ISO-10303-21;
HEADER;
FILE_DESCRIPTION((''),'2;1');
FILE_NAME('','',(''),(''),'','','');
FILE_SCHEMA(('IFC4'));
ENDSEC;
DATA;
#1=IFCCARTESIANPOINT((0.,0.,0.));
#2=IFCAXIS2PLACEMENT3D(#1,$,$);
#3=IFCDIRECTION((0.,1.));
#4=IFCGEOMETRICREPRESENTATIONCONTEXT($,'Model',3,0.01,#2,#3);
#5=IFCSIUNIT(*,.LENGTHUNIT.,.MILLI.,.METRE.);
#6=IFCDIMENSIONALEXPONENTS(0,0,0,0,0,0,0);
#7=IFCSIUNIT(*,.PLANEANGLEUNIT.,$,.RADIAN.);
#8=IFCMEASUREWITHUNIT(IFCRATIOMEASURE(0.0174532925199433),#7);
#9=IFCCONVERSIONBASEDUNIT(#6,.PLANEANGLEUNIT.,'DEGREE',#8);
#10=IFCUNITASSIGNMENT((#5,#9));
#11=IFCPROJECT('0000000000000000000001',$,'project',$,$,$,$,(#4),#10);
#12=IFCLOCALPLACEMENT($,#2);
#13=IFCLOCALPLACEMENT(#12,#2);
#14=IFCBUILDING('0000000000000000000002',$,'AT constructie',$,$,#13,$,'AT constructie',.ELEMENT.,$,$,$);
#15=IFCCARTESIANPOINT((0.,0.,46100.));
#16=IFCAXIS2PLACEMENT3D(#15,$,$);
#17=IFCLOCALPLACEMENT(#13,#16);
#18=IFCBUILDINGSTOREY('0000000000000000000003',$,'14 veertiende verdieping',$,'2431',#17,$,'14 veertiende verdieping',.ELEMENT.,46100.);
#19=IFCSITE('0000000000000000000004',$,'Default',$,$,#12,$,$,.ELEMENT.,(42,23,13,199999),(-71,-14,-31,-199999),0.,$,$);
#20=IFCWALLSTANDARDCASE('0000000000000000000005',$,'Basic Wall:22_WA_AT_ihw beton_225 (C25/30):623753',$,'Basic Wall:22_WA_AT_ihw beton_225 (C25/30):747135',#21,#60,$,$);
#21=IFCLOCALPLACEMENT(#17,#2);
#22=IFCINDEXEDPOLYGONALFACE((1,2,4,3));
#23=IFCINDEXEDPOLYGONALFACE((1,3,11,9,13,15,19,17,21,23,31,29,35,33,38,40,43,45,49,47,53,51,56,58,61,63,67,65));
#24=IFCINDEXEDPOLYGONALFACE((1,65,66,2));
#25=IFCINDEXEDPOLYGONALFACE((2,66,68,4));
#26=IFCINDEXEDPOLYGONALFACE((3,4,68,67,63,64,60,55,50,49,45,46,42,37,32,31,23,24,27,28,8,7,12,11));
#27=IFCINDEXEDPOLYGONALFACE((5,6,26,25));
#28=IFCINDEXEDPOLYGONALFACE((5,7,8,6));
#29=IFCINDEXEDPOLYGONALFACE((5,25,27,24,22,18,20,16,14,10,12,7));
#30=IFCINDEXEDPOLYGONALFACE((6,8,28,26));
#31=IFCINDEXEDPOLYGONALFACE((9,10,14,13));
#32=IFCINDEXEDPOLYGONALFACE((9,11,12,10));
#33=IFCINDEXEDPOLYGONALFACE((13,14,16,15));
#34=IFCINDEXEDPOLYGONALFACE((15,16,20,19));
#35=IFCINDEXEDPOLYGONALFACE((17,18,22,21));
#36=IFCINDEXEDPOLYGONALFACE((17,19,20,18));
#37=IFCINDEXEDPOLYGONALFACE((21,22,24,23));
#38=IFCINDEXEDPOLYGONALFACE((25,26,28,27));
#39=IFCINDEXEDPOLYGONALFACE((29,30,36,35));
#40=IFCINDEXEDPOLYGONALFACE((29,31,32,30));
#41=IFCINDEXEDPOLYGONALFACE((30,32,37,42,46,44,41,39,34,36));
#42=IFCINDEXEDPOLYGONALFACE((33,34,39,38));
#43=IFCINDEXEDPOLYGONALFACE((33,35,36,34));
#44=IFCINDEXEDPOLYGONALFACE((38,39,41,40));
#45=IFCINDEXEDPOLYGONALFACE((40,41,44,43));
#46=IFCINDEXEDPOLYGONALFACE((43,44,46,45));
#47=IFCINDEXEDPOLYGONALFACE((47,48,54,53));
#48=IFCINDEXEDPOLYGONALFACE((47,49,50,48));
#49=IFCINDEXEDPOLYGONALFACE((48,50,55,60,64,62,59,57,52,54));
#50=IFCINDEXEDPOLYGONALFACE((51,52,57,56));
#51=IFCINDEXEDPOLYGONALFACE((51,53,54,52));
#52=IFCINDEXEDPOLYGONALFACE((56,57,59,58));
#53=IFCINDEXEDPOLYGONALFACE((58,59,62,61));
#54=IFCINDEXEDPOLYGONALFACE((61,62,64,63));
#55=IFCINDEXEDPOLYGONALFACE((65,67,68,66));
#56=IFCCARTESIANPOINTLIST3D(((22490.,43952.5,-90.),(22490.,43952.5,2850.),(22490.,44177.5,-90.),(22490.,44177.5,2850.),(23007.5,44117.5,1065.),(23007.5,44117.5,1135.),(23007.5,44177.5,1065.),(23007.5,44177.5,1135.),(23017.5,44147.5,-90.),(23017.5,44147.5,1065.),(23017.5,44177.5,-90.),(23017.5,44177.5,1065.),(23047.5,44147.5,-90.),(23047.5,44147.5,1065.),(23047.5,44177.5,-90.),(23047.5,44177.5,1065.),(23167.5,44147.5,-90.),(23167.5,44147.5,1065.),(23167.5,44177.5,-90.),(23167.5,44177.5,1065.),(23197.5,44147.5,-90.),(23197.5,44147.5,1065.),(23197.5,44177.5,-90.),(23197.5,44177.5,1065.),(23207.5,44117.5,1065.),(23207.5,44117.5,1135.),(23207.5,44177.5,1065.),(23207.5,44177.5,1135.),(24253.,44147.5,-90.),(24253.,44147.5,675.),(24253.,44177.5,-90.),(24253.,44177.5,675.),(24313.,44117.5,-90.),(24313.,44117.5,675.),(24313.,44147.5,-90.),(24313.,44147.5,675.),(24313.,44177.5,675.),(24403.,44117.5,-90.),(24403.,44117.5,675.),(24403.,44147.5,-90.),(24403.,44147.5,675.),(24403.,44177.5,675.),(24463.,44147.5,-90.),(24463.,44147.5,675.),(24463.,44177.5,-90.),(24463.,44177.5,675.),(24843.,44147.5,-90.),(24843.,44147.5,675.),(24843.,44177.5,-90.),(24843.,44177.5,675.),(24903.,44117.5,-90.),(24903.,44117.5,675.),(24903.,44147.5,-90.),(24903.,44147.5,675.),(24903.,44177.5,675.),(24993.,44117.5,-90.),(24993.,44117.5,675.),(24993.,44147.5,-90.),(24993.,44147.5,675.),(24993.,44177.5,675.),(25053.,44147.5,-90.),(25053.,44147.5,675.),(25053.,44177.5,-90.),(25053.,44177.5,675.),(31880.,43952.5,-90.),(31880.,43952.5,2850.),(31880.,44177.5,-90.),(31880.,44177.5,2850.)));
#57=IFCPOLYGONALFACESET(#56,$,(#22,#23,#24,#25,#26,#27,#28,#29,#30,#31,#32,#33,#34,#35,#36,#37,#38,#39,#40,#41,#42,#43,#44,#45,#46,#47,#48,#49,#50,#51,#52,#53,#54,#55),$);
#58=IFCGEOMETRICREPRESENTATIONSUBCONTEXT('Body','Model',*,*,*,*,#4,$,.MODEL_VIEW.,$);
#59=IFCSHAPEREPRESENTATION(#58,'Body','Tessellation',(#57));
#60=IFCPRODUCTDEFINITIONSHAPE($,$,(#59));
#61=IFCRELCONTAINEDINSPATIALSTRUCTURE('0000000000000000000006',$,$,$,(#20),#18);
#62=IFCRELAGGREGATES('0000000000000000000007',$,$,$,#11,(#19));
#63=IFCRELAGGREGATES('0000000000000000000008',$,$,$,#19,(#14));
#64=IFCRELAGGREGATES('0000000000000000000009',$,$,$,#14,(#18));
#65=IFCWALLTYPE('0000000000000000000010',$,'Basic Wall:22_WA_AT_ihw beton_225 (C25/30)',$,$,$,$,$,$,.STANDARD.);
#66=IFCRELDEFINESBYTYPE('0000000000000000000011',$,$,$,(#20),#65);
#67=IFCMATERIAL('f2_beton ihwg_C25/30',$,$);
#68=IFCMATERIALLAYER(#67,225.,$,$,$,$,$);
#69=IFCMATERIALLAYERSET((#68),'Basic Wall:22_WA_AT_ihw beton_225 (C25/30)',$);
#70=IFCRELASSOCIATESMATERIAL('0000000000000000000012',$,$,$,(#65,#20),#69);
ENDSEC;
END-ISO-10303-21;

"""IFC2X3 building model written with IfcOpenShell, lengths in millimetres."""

from ifc_helpers import new_model, entity, si_unit, converted_unit, direction, frame, frame_2d, origin, place, context, subcontext, project, spatial, rectangle, extrude, material, layer, layer_set, layer_usage, type_object, element, save


model = new_model("IFC2X3")

# Units and contexts
model_context = context("Model", 3, precision=0.01, world=origin(), true_north=direction((0.0, 1.0)))
body_context = subcontext(model_context, "Body", "Model", "MODEL_VIEW")
ifc_project = project(units=[si_unit("LENGTHUNIT", "METRE", prefix="MILLI"), converted_unit("PLANEANGLEUNIT", "DEGREE", entity("IfcRatioMeasure", 0.0174532925199433), si_unit("PLANEANGLEUNIT", "RADIAN"), dimensions=[0, 0, 0, 0, 0, 0, 0])], contexts=[model_context])

# Site, building, storey
site_placement = place(None, origin())
site = spatial("IfcSite", under=ifc_project, at=site_placement, Name="Default", CompositionType="ELEMENT", RefLatitude=(42, 23, 13, 199999), RefLongitude=(-71, -14, -31, -199999), RefElevation=0.0)
building_placement = place(site_placement, origin())
building = spatial("IfcBuilding", under=site, at=building_placement, Name="AT constructie", LongName="AT constructie", CompositionType="ELEMENT")
storey_placement = place(building_placement, frame((0.0, 0.0, 46100.0)))
storey = spatial("IfcBuildingStorey", under=building, at=storey_placement, Name="14 veertiende verdieping", ObjectType="2431", LongName="14 veertiende verdieping", CompositionType="ELEMENT", Elevation=46100.0)

# Shared definitions
ifc_material_1 = material(Name="f2_beton ihwg_C25/30")

# Wall, openings
ifc_layer_1 = layer(ifc_material_1, 225.0)
ifc_layer_set_1 = layer_set([ifc_layer_1], Name="Basic Wall:22_WA_AT_ihw beton_225 (C25/30)")
ifc_layer_usage_1 = layer_usage(ifc_layer_set_1, "AXIS2", "NEGATIVE", 112.5)
wall_type = type_object("IfcWallType", Name="Basic Wall:22_WA_AT_ihw beton_225 (C25/30)", PredefinedType="STANDARD", material=ifc_layer_set_1)
wall_placement = place(storey_placement, frame((22490.0, 44065.0, -90.0)))
wall = element("IfcWallStandardCase", 1, at=wall_placement, inside=storey, type_object=wall_type, material=ifc_layer_usage_1, Name="Basic Wall:22_WA_AT_ihw beton_225 (C25/30):623753", ObjectType="Basic Wall:22_WA_AT_ihw beton_225 (C25/30):747135", context=body_context, shape_type="SweptSolid", body=[
    extrude(rectangle(XDim=9390.0, YDim=225.0, at=frame_2d((4695.0, 0.0), x_axis=(-1.0, 0.0))), origin(), (0.0, 0.0, 1.0), 2940.0),
])
opening_1_placement = place(wall_placement, origin())
element("IfcOpeningElement", 2, at=opening_1_placement, cuts=wall, ObjectType="Recess", context=body_context, shape_type="SweptSolid", body=[
    extrude(rectangle(XDim=765.0, YDim=90.0, at=frame_2d((0.0, 0.0), x_axis=(0.0, 1.0))), frame((2458.0, 52.5, 382.5), z_axis=(0.0, 1.0, 0.0), x_axis=(1.0, 0.0, 0.0)), (0.0, 0.0, 1.0), 60.0),
])
opening_2_placement = place(wall_placement, origin())
element("IfcOpeningElement", 3, at=opening_2_placement, cuts=wall, ObjectType="Recess", context=body_context, shape_type="SweptSolid", body=[
    extrude(rectangle(XDim=765.0, YDim=60.0, at=frame_2d((0.0, 0.0), x_axis=(0.0, 1.0))), frame((2533.0, 82.5, 382.5), z_axis=(0.0, 1.0, 0.0), x_axis=(1.0, 0.0, 0.0)), (0.0, 0.0, 1.0), 30.0),
])
opening_3_placement = place(wall_placement, origin())
element("IfcOpeningElement", 4, at=opening_3_placement, cuts=wall, ObjectType="Recess", context=body_context, shape_type="SweptSolid", body=[
    extrude(rectangle(XDim=765.0, YDim=60.0, at=frame_2d((0.0, 0.0), x_axis=(0.0, 1.0))), frame((2383.0, 82.5, 382.5), z_axis=(0.0, 1.0, 0.0), x_axis=(1.0, 0.0, 0.0)), (0.0, 0.0, 1.0), 30.0),
])
opening_4_placement = place(wall_placement, origin())
element("IfcOpeningElement", 5, at=opening_4_placement, cuts=wall, ObjectType="Recess", context=body_context, shape_type="SweptSolid", body=[
    extrude(rectangle(XDim=765.0, YDim=60.0, at=frame_2d((0.0, 0.0), x_axis=(0.0, 1.0))), frame((1793.0, 82.5, 382.5), z_axis=(0.0, 1.0, 0.0), x_axis=(1.0, 0.0, 0.0)), (0.0, 0.0, 1.0), 30.0),
])
opening_5_placement = place(wall_placement, origin())
element("IfcOpeningElement", 6, at=opening_5_placement, cuts=wall, ObjectType="Recess", context=body_context, shape_type="SweptSolid", body=[
    extrude(rectangle(XDim=765.0, YDim=60.0, at=frame_2d((0.0, 0.0), x_axis=(0.0, 1.0))), frame((1943.0, 82.5, 382.5), z_axis=(0.0, 1.0, 0.0), x_axis=(1.0, 0.0, 0.0)), (0.0, 0.0, 1.0), 30.0),
])
opening_6_placement = place(wall_placement, origin())
element("IfcOpeningElement", 7, at=opening_6_placement, cuts=wall, ObjectType="Recess", context=body_context, shape_type="SweptSolid", body=[
    extrude(rectangle(XDim=765.0, YDim=90.0, at=frame_2d((0.0, 0.0), x_axis=(0.0, 1.0))), frame((1868.0, 52.5, 382.5), z_axis=(0.0, 1.0, 0.0), x_axis=(1.0, 0.0, 0.0)), (0.0, 0.0, 1.0), 60.0),
])
opening_7_placement = place(wall_placement, origin())
element("IfcOpeningElement", 8, at=opening_7_placement, cuts=wall, ObjectType="Recess", context=body_context, shape_type="SweptSolid", body=[
    extrude(rectangle(XDim=1155.0, YDim=30.0, at=frame_2d((0.0, 0.0), x_axis=(0.0, 1.0))), frame((692.5, 82.5, 577.5), z_axis=(0.0, 1.0, 0.0), x_axis=(1.0, 0.0, 0.0)), (0.0, 0.0, 1.0), 30.0),
])
opening_8_placement = place(wall_placement, origin())
element("IfcOpeningElement", 9, at=opening_8_placement, cuts=wall, ObjectType="Recess", context=body_context, shape_type="SweptSolid", body=[
    extrude(rectangle(XDim=1155.0, YDim=30.0, at=frame_2d((0.0, 0.0), x_axis=(0.0, 1.0))), frame((542.5, 82.5, 577.5), z_axis=(0.0, 1.0, 0.0), x_axis=(1.0, 0.0, 0.0)), (0.0, 0.0, 1.0), 30.0),
])
opening_9_placement = place(wall_placement, origin())
element("IfcOpeningElement", 10, at=opening_9_placement, cuts=wall, ObjectType="Recess", context=body_context, shape_type="SweptSolid", body=[
    extrude(rectangle(XDim=70.0, YDim=200.0, at=frame_2d((0.0, 0.0), x_axis=(0.0, 1.0))), frame((617.5, 52.5, 1190.0), z_axis=(0.0, 1.0, 0.0), x_axis=(1.0, 0.0, 0.0)), (0.0, 0.0, 1.0), 60.0),
])

save(model, "model.ifc")
